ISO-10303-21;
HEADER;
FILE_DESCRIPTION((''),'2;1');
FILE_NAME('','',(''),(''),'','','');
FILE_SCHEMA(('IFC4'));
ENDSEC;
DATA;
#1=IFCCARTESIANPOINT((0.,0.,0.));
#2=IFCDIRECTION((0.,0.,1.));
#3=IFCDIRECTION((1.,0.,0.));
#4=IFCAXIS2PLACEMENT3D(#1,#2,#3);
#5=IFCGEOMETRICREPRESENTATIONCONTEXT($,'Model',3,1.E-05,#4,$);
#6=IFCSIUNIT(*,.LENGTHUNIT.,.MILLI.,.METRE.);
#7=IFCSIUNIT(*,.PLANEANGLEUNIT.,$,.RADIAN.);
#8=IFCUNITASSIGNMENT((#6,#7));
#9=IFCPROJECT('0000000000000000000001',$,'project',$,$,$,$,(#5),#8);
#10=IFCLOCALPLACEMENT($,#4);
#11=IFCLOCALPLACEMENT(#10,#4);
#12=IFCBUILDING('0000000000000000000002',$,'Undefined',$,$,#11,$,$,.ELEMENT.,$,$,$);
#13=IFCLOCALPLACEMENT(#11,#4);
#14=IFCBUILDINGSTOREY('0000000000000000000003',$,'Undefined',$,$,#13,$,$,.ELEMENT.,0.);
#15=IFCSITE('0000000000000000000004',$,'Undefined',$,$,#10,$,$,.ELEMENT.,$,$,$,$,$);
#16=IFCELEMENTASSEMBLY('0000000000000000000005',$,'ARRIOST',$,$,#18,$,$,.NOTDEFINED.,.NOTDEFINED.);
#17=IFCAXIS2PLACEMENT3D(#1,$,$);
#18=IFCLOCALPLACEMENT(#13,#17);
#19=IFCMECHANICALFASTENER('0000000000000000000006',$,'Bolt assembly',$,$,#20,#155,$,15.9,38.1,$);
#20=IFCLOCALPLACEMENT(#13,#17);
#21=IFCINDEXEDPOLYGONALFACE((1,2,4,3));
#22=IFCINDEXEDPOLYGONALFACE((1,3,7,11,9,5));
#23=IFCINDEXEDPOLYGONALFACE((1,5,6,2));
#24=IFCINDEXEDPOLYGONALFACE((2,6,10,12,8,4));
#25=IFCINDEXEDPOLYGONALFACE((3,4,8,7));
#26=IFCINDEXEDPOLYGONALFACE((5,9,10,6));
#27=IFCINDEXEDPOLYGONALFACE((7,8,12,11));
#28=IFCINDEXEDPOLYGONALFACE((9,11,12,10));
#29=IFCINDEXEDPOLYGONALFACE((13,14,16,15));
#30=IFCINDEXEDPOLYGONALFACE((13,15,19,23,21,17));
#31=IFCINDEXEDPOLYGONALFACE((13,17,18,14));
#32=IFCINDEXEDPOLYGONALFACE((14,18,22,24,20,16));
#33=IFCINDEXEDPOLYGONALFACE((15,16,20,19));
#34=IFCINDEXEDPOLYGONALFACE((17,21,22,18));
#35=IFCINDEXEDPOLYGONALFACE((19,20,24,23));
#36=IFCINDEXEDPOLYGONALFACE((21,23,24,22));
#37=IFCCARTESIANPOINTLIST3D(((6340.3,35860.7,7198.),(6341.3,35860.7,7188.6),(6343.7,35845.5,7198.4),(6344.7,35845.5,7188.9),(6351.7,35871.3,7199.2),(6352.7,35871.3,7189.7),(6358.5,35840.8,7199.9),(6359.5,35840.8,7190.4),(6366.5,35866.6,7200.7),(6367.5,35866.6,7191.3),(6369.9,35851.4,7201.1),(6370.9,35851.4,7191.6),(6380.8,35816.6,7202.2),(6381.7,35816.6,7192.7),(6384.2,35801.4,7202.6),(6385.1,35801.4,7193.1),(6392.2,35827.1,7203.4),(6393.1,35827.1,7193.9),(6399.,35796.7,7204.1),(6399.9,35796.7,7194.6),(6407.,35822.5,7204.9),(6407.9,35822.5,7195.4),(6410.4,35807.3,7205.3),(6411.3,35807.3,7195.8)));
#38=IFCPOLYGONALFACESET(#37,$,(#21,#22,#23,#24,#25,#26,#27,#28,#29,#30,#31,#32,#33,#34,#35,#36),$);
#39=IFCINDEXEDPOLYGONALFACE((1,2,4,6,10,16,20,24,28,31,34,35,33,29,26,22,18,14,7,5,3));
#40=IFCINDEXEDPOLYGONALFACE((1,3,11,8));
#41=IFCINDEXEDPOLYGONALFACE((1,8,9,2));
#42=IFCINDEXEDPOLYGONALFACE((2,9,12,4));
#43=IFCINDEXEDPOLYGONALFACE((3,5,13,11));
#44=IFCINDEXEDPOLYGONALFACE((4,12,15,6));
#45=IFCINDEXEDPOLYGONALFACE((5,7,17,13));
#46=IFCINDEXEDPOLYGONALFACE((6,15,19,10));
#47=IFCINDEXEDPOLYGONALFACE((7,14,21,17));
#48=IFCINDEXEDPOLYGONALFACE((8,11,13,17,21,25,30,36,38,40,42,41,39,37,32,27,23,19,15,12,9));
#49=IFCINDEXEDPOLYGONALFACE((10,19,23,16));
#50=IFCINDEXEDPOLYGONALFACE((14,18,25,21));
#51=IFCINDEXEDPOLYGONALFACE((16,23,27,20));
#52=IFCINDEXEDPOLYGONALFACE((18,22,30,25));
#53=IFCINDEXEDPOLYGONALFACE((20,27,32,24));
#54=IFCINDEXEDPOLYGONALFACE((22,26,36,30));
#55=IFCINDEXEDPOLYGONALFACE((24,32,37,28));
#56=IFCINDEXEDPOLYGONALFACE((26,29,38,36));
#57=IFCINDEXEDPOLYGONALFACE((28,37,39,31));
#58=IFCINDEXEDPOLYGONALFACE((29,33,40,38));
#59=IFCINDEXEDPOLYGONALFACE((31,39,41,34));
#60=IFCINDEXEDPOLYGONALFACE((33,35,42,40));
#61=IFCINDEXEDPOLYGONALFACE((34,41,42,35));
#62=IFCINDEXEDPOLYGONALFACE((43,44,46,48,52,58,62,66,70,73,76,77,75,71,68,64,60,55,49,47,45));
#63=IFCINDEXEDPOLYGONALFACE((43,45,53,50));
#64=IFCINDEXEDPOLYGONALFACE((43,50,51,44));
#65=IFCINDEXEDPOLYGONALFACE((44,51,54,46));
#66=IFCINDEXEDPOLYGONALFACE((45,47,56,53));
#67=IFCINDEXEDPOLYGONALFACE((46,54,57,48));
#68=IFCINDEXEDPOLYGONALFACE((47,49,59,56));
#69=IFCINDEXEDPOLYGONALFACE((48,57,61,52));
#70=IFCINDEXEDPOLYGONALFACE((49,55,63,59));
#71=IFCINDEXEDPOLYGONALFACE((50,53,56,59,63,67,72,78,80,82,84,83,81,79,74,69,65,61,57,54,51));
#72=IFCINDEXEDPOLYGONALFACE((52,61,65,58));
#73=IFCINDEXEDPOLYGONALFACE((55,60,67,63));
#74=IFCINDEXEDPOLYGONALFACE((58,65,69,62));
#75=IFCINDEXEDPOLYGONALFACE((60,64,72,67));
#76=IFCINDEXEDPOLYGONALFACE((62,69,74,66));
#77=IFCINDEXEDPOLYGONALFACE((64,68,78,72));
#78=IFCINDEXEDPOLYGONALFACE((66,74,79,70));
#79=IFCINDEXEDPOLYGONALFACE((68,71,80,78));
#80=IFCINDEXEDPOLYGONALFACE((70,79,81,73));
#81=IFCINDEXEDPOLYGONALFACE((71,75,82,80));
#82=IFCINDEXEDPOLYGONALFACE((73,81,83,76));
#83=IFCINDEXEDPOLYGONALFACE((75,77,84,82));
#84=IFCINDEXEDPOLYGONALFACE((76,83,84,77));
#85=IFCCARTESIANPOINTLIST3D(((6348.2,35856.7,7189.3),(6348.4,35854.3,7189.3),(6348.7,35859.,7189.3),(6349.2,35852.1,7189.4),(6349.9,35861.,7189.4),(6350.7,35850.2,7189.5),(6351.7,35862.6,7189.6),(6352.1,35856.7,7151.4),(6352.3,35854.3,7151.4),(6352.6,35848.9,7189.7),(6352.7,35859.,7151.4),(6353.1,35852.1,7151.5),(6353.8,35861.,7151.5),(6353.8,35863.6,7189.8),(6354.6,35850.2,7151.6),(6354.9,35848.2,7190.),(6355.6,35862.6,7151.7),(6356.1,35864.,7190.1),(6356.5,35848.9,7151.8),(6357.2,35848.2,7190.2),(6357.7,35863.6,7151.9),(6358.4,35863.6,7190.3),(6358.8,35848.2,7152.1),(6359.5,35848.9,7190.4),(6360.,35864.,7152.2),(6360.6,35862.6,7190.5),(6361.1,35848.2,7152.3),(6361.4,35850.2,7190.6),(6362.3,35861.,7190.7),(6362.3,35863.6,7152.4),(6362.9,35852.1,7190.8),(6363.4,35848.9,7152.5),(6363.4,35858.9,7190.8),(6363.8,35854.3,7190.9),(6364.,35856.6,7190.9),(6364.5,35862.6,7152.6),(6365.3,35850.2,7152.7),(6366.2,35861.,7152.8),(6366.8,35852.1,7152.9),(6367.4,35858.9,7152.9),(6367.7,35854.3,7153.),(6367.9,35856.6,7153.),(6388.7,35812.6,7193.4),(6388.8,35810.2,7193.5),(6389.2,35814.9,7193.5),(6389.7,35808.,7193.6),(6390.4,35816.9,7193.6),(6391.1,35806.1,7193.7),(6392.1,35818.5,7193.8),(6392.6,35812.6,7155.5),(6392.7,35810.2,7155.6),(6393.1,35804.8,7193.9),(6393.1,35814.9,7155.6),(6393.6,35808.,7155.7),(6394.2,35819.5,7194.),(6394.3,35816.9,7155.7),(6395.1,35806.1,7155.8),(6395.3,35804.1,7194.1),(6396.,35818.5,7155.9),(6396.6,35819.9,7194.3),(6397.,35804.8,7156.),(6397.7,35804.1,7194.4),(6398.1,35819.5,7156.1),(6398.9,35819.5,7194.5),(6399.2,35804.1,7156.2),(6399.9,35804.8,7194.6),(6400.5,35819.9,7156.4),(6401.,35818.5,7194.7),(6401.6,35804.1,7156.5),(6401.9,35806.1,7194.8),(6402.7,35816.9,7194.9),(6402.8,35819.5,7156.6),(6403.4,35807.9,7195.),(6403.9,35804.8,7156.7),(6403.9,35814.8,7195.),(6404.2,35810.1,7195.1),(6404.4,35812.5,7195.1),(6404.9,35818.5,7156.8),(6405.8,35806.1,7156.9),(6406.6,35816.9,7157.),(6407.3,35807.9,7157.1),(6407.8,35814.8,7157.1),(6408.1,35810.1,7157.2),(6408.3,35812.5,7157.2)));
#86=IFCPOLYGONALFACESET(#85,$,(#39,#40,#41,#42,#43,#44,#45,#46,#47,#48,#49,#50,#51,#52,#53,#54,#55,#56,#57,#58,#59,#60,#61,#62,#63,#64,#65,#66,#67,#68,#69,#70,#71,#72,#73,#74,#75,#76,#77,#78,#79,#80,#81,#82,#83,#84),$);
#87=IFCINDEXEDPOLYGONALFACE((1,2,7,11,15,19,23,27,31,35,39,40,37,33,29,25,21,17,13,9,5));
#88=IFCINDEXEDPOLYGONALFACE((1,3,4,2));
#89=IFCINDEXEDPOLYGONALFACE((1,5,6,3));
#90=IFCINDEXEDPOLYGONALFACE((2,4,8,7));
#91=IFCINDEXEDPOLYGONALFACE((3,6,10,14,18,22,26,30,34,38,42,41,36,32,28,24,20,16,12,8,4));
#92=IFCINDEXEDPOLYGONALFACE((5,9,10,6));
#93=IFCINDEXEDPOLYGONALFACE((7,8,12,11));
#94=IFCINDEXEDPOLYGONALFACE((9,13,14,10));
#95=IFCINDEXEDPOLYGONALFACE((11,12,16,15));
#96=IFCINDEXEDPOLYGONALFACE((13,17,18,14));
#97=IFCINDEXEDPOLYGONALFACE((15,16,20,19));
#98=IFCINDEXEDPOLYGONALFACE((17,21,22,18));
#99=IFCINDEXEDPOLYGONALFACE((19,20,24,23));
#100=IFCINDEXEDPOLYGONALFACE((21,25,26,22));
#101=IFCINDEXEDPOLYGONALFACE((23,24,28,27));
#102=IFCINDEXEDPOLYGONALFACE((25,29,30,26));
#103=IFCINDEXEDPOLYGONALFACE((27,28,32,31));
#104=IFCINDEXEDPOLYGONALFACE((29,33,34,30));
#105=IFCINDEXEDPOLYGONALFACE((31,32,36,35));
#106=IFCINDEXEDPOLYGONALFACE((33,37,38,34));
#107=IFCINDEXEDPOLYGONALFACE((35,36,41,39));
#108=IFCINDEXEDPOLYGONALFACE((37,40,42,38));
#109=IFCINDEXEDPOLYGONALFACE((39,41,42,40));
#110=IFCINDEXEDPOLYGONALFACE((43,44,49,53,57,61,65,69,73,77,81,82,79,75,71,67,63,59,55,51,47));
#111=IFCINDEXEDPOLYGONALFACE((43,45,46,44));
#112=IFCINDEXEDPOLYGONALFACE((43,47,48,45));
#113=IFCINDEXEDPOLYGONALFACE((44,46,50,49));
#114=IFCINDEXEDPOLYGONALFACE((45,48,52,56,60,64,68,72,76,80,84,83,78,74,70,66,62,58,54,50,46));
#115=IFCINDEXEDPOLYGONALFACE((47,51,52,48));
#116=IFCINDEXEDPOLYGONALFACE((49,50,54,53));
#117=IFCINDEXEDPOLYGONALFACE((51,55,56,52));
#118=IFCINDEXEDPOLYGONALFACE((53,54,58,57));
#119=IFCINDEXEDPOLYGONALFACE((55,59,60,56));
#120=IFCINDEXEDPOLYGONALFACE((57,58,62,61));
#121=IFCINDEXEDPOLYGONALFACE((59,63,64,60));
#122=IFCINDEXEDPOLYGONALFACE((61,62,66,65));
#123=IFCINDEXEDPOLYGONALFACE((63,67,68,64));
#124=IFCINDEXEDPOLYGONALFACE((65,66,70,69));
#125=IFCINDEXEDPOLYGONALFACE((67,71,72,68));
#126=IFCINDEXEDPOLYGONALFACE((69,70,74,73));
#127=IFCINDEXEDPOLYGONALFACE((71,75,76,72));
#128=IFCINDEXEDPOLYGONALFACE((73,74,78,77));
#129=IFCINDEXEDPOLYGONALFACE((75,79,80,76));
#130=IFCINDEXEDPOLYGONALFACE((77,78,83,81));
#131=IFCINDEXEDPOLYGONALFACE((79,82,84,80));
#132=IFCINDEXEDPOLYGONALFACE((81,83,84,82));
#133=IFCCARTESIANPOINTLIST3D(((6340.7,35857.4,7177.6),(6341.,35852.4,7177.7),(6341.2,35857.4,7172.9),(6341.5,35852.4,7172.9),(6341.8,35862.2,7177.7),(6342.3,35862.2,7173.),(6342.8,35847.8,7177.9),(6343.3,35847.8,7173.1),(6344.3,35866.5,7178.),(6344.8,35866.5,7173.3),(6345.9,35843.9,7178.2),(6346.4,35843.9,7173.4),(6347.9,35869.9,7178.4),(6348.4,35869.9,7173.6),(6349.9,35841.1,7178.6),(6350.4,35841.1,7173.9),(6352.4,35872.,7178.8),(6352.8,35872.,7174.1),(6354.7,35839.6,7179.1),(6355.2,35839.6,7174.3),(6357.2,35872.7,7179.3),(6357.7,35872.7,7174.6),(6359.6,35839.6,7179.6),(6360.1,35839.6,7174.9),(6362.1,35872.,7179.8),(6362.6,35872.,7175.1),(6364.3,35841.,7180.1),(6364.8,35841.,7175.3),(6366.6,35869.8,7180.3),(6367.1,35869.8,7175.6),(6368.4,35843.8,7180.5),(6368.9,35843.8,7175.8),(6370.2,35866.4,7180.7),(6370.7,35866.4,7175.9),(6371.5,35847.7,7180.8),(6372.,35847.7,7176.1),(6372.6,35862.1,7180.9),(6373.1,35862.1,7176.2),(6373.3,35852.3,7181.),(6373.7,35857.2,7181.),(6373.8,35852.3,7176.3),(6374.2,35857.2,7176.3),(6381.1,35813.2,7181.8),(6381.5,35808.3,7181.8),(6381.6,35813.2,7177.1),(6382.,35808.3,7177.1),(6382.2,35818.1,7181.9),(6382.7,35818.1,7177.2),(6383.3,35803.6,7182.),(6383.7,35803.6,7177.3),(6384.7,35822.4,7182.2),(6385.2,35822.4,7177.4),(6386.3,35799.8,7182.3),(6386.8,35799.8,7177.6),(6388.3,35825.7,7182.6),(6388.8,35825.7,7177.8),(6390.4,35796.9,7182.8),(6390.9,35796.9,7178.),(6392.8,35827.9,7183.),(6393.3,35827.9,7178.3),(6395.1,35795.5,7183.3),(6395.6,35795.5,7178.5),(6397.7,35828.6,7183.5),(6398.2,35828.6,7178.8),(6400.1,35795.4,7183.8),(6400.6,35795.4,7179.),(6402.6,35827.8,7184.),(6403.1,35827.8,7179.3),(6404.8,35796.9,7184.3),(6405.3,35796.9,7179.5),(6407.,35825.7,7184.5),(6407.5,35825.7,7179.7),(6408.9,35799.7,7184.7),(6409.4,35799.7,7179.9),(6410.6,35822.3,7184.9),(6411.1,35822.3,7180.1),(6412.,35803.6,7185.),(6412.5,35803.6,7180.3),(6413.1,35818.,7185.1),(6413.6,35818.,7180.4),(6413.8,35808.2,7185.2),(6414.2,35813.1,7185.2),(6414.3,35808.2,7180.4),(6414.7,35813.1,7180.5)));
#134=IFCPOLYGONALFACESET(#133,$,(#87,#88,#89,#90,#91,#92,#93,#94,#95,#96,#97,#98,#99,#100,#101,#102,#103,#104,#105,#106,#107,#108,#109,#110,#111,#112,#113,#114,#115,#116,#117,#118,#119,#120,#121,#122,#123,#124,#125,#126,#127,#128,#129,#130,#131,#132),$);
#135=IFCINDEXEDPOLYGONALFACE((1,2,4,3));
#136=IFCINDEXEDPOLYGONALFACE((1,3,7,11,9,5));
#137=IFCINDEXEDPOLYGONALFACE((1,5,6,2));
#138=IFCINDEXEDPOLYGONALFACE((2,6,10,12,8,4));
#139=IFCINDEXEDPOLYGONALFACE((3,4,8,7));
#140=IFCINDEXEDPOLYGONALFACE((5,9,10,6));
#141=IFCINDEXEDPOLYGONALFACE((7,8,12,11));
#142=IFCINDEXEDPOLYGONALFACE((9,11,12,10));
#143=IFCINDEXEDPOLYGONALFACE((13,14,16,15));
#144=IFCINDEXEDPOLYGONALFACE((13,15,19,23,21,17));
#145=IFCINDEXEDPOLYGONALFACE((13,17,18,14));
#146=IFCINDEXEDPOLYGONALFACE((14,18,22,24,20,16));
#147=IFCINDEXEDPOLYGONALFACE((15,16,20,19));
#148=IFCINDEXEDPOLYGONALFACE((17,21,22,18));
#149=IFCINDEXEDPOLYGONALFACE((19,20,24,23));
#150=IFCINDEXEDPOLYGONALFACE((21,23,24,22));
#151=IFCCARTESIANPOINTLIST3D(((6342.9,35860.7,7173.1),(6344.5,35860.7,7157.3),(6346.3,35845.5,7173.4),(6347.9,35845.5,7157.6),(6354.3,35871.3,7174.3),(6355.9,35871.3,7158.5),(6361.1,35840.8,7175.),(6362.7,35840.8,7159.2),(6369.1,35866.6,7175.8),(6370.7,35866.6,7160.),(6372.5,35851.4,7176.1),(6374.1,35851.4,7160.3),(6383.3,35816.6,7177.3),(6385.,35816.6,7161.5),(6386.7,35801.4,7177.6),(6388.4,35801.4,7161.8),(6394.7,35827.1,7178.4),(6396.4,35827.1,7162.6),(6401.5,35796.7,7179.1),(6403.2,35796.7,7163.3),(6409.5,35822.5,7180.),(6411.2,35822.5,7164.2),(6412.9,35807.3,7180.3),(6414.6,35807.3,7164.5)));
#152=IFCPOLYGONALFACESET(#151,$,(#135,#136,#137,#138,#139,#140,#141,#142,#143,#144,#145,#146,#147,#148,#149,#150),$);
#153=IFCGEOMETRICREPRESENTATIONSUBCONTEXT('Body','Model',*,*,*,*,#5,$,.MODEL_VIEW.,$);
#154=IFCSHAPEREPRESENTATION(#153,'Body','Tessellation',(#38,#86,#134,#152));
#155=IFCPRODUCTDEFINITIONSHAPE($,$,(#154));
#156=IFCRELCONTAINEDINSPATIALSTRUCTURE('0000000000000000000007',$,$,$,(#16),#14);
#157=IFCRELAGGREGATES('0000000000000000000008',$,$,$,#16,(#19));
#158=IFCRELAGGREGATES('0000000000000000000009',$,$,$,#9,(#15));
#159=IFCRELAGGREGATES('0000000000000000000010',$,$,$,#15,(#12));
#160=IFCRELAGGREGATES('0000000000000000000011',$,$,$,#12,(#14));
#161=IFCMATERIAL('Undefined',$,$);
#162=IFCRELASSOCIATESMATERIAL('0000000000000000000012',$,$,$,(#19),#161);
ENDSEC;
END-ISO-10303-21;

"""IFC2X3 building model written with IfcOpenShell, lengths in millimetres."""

from ifc_helpers import new_model, si_unit, frame, origin_with_axes, origin_2d_with_axis, place, context, subcontext, project, spatial, polyline, circle, outline, extrude, source, transform, mapped, material, element, aggregate, save


model = new_model("IFC2X3")

# Units and contexts
model_context = context("Model", 3, precision=1e-05, world=origin_with_axes())
body_context = subcontext(model_context, "Body", "Model", "MODEL_VIEW")
ifc_project = project(units=[si_unit("LENGTHUNIT", "METRE", prefix="MILLI"), si_unit("PLANEANGLEUNIT", "RADIAN")], contexts=[model_context])

# Site, building, storey
site_placement = place(None, origin_with_axes())
site = spatial("IfcSite", under=ifc_project, at=site_placement, Name="Undefined", CompositionType="ELEMENT")
building_placement = place(site_placement, origin_with_axes())
building = spatial("IfcBuilding", under=site, at=building_placement, Name="Undefined", CompositionType="ELEMENT")
storey_placement = place(building_placement, origin_with_axes())
storey = spatial("IfcBuildingStorey", under=building, at=storey_placement, Name="Undefined", CompositionType="ELEMENT", Elevation=0.0)

# Shared definitions
ifc_material_1 = material(Name="Undefined")

# Element assembly, mechanical fastener
assembly_1_placement = place(storey_placement, origin_with_axes())
assembly_1 = element("IfcElementAssembly", 1, at=assembly_1_placement, inside=storey, Name="ARRIOST", AssemblyPlace="NOTDEFINED", PredefinedType="NOTDEFINED")
shared_shape_1 = source(origin_with_axes(), body_context, "Body", "SweptSolid", [
    extrude(outline(polyline([(13.5, -7.8), (13.5, 7.8), (0.0, 15.6), (-13.5, 7.8), (-13.5, -7.8), (0.0, -15.6), (13.5, -7.8)])), frame((0.0, -9.5, 0.0), z_axis=(0.0, 1.0, 0.0), x_axis=(1.0, 0.0, 0.0)), (0.0, 0.0, 1.0), 9.5),
    extrude(circle(Radius=7.9, at=origin_2d_with_axis()), frame((0.0, 0.0, 0.0), z_axis=(0.0, 1.0, 0.0), x_axis=(1.0, 0.0, 0.0)), (0.0, 0.0, 1.0), 38.1),
    extrude(circle(Radius=16.7, at=origin_2d_with_axis()), frame((0.0, 10.8, 0.0), z_axis=(0.0, 1.0, 0.0), x_axis=(1.0, 0.0, 0.0)), (0.0, 0.0, 1.0), 4.8),
    extrude(outline(polyline([(13.5, -7.8), (13.5, 7.8), (0.0, 15.6), (-13.5, 7.8), (-13.5, -7.8), (0.0, -15.6), (13.5, -7.8)])), frame((0.0, 15.6, 0.0), z_axis=(0.0, 1.0, 0.0), x_axis=(1.0, 0.0, 0.0)), (0.0, 0.0, 1.0), 15.9),
])
mechanical_fastener_1_placement = place(assembly_1_placement, frame((6356.1, 35856.1, 7190.1), z_axis=(0.731384, 0.677774, 0.075494), x_axis=(0.674192, -0.73527, 0.069591)))
mechanical_fastener_1 = element("IfcMechanicalFastener", 2, at=mechanical_fastener_1_placement, material=ifc_material_1, Name="Bolt assembly", NominalDiameter=15.9, NominalLength=38.1, context=body_context, shape_type="MappedRepresentation", body=[
    mapped(shared_shape_1, transform((0.0, 0.0, 0.0))),
    mapped(shared_shape_1, transform((60.0, 0.0, 0.0))),
])
aggregate(assembly_1, [mechanical_fastener_1])

save(model, "model.ifc")
